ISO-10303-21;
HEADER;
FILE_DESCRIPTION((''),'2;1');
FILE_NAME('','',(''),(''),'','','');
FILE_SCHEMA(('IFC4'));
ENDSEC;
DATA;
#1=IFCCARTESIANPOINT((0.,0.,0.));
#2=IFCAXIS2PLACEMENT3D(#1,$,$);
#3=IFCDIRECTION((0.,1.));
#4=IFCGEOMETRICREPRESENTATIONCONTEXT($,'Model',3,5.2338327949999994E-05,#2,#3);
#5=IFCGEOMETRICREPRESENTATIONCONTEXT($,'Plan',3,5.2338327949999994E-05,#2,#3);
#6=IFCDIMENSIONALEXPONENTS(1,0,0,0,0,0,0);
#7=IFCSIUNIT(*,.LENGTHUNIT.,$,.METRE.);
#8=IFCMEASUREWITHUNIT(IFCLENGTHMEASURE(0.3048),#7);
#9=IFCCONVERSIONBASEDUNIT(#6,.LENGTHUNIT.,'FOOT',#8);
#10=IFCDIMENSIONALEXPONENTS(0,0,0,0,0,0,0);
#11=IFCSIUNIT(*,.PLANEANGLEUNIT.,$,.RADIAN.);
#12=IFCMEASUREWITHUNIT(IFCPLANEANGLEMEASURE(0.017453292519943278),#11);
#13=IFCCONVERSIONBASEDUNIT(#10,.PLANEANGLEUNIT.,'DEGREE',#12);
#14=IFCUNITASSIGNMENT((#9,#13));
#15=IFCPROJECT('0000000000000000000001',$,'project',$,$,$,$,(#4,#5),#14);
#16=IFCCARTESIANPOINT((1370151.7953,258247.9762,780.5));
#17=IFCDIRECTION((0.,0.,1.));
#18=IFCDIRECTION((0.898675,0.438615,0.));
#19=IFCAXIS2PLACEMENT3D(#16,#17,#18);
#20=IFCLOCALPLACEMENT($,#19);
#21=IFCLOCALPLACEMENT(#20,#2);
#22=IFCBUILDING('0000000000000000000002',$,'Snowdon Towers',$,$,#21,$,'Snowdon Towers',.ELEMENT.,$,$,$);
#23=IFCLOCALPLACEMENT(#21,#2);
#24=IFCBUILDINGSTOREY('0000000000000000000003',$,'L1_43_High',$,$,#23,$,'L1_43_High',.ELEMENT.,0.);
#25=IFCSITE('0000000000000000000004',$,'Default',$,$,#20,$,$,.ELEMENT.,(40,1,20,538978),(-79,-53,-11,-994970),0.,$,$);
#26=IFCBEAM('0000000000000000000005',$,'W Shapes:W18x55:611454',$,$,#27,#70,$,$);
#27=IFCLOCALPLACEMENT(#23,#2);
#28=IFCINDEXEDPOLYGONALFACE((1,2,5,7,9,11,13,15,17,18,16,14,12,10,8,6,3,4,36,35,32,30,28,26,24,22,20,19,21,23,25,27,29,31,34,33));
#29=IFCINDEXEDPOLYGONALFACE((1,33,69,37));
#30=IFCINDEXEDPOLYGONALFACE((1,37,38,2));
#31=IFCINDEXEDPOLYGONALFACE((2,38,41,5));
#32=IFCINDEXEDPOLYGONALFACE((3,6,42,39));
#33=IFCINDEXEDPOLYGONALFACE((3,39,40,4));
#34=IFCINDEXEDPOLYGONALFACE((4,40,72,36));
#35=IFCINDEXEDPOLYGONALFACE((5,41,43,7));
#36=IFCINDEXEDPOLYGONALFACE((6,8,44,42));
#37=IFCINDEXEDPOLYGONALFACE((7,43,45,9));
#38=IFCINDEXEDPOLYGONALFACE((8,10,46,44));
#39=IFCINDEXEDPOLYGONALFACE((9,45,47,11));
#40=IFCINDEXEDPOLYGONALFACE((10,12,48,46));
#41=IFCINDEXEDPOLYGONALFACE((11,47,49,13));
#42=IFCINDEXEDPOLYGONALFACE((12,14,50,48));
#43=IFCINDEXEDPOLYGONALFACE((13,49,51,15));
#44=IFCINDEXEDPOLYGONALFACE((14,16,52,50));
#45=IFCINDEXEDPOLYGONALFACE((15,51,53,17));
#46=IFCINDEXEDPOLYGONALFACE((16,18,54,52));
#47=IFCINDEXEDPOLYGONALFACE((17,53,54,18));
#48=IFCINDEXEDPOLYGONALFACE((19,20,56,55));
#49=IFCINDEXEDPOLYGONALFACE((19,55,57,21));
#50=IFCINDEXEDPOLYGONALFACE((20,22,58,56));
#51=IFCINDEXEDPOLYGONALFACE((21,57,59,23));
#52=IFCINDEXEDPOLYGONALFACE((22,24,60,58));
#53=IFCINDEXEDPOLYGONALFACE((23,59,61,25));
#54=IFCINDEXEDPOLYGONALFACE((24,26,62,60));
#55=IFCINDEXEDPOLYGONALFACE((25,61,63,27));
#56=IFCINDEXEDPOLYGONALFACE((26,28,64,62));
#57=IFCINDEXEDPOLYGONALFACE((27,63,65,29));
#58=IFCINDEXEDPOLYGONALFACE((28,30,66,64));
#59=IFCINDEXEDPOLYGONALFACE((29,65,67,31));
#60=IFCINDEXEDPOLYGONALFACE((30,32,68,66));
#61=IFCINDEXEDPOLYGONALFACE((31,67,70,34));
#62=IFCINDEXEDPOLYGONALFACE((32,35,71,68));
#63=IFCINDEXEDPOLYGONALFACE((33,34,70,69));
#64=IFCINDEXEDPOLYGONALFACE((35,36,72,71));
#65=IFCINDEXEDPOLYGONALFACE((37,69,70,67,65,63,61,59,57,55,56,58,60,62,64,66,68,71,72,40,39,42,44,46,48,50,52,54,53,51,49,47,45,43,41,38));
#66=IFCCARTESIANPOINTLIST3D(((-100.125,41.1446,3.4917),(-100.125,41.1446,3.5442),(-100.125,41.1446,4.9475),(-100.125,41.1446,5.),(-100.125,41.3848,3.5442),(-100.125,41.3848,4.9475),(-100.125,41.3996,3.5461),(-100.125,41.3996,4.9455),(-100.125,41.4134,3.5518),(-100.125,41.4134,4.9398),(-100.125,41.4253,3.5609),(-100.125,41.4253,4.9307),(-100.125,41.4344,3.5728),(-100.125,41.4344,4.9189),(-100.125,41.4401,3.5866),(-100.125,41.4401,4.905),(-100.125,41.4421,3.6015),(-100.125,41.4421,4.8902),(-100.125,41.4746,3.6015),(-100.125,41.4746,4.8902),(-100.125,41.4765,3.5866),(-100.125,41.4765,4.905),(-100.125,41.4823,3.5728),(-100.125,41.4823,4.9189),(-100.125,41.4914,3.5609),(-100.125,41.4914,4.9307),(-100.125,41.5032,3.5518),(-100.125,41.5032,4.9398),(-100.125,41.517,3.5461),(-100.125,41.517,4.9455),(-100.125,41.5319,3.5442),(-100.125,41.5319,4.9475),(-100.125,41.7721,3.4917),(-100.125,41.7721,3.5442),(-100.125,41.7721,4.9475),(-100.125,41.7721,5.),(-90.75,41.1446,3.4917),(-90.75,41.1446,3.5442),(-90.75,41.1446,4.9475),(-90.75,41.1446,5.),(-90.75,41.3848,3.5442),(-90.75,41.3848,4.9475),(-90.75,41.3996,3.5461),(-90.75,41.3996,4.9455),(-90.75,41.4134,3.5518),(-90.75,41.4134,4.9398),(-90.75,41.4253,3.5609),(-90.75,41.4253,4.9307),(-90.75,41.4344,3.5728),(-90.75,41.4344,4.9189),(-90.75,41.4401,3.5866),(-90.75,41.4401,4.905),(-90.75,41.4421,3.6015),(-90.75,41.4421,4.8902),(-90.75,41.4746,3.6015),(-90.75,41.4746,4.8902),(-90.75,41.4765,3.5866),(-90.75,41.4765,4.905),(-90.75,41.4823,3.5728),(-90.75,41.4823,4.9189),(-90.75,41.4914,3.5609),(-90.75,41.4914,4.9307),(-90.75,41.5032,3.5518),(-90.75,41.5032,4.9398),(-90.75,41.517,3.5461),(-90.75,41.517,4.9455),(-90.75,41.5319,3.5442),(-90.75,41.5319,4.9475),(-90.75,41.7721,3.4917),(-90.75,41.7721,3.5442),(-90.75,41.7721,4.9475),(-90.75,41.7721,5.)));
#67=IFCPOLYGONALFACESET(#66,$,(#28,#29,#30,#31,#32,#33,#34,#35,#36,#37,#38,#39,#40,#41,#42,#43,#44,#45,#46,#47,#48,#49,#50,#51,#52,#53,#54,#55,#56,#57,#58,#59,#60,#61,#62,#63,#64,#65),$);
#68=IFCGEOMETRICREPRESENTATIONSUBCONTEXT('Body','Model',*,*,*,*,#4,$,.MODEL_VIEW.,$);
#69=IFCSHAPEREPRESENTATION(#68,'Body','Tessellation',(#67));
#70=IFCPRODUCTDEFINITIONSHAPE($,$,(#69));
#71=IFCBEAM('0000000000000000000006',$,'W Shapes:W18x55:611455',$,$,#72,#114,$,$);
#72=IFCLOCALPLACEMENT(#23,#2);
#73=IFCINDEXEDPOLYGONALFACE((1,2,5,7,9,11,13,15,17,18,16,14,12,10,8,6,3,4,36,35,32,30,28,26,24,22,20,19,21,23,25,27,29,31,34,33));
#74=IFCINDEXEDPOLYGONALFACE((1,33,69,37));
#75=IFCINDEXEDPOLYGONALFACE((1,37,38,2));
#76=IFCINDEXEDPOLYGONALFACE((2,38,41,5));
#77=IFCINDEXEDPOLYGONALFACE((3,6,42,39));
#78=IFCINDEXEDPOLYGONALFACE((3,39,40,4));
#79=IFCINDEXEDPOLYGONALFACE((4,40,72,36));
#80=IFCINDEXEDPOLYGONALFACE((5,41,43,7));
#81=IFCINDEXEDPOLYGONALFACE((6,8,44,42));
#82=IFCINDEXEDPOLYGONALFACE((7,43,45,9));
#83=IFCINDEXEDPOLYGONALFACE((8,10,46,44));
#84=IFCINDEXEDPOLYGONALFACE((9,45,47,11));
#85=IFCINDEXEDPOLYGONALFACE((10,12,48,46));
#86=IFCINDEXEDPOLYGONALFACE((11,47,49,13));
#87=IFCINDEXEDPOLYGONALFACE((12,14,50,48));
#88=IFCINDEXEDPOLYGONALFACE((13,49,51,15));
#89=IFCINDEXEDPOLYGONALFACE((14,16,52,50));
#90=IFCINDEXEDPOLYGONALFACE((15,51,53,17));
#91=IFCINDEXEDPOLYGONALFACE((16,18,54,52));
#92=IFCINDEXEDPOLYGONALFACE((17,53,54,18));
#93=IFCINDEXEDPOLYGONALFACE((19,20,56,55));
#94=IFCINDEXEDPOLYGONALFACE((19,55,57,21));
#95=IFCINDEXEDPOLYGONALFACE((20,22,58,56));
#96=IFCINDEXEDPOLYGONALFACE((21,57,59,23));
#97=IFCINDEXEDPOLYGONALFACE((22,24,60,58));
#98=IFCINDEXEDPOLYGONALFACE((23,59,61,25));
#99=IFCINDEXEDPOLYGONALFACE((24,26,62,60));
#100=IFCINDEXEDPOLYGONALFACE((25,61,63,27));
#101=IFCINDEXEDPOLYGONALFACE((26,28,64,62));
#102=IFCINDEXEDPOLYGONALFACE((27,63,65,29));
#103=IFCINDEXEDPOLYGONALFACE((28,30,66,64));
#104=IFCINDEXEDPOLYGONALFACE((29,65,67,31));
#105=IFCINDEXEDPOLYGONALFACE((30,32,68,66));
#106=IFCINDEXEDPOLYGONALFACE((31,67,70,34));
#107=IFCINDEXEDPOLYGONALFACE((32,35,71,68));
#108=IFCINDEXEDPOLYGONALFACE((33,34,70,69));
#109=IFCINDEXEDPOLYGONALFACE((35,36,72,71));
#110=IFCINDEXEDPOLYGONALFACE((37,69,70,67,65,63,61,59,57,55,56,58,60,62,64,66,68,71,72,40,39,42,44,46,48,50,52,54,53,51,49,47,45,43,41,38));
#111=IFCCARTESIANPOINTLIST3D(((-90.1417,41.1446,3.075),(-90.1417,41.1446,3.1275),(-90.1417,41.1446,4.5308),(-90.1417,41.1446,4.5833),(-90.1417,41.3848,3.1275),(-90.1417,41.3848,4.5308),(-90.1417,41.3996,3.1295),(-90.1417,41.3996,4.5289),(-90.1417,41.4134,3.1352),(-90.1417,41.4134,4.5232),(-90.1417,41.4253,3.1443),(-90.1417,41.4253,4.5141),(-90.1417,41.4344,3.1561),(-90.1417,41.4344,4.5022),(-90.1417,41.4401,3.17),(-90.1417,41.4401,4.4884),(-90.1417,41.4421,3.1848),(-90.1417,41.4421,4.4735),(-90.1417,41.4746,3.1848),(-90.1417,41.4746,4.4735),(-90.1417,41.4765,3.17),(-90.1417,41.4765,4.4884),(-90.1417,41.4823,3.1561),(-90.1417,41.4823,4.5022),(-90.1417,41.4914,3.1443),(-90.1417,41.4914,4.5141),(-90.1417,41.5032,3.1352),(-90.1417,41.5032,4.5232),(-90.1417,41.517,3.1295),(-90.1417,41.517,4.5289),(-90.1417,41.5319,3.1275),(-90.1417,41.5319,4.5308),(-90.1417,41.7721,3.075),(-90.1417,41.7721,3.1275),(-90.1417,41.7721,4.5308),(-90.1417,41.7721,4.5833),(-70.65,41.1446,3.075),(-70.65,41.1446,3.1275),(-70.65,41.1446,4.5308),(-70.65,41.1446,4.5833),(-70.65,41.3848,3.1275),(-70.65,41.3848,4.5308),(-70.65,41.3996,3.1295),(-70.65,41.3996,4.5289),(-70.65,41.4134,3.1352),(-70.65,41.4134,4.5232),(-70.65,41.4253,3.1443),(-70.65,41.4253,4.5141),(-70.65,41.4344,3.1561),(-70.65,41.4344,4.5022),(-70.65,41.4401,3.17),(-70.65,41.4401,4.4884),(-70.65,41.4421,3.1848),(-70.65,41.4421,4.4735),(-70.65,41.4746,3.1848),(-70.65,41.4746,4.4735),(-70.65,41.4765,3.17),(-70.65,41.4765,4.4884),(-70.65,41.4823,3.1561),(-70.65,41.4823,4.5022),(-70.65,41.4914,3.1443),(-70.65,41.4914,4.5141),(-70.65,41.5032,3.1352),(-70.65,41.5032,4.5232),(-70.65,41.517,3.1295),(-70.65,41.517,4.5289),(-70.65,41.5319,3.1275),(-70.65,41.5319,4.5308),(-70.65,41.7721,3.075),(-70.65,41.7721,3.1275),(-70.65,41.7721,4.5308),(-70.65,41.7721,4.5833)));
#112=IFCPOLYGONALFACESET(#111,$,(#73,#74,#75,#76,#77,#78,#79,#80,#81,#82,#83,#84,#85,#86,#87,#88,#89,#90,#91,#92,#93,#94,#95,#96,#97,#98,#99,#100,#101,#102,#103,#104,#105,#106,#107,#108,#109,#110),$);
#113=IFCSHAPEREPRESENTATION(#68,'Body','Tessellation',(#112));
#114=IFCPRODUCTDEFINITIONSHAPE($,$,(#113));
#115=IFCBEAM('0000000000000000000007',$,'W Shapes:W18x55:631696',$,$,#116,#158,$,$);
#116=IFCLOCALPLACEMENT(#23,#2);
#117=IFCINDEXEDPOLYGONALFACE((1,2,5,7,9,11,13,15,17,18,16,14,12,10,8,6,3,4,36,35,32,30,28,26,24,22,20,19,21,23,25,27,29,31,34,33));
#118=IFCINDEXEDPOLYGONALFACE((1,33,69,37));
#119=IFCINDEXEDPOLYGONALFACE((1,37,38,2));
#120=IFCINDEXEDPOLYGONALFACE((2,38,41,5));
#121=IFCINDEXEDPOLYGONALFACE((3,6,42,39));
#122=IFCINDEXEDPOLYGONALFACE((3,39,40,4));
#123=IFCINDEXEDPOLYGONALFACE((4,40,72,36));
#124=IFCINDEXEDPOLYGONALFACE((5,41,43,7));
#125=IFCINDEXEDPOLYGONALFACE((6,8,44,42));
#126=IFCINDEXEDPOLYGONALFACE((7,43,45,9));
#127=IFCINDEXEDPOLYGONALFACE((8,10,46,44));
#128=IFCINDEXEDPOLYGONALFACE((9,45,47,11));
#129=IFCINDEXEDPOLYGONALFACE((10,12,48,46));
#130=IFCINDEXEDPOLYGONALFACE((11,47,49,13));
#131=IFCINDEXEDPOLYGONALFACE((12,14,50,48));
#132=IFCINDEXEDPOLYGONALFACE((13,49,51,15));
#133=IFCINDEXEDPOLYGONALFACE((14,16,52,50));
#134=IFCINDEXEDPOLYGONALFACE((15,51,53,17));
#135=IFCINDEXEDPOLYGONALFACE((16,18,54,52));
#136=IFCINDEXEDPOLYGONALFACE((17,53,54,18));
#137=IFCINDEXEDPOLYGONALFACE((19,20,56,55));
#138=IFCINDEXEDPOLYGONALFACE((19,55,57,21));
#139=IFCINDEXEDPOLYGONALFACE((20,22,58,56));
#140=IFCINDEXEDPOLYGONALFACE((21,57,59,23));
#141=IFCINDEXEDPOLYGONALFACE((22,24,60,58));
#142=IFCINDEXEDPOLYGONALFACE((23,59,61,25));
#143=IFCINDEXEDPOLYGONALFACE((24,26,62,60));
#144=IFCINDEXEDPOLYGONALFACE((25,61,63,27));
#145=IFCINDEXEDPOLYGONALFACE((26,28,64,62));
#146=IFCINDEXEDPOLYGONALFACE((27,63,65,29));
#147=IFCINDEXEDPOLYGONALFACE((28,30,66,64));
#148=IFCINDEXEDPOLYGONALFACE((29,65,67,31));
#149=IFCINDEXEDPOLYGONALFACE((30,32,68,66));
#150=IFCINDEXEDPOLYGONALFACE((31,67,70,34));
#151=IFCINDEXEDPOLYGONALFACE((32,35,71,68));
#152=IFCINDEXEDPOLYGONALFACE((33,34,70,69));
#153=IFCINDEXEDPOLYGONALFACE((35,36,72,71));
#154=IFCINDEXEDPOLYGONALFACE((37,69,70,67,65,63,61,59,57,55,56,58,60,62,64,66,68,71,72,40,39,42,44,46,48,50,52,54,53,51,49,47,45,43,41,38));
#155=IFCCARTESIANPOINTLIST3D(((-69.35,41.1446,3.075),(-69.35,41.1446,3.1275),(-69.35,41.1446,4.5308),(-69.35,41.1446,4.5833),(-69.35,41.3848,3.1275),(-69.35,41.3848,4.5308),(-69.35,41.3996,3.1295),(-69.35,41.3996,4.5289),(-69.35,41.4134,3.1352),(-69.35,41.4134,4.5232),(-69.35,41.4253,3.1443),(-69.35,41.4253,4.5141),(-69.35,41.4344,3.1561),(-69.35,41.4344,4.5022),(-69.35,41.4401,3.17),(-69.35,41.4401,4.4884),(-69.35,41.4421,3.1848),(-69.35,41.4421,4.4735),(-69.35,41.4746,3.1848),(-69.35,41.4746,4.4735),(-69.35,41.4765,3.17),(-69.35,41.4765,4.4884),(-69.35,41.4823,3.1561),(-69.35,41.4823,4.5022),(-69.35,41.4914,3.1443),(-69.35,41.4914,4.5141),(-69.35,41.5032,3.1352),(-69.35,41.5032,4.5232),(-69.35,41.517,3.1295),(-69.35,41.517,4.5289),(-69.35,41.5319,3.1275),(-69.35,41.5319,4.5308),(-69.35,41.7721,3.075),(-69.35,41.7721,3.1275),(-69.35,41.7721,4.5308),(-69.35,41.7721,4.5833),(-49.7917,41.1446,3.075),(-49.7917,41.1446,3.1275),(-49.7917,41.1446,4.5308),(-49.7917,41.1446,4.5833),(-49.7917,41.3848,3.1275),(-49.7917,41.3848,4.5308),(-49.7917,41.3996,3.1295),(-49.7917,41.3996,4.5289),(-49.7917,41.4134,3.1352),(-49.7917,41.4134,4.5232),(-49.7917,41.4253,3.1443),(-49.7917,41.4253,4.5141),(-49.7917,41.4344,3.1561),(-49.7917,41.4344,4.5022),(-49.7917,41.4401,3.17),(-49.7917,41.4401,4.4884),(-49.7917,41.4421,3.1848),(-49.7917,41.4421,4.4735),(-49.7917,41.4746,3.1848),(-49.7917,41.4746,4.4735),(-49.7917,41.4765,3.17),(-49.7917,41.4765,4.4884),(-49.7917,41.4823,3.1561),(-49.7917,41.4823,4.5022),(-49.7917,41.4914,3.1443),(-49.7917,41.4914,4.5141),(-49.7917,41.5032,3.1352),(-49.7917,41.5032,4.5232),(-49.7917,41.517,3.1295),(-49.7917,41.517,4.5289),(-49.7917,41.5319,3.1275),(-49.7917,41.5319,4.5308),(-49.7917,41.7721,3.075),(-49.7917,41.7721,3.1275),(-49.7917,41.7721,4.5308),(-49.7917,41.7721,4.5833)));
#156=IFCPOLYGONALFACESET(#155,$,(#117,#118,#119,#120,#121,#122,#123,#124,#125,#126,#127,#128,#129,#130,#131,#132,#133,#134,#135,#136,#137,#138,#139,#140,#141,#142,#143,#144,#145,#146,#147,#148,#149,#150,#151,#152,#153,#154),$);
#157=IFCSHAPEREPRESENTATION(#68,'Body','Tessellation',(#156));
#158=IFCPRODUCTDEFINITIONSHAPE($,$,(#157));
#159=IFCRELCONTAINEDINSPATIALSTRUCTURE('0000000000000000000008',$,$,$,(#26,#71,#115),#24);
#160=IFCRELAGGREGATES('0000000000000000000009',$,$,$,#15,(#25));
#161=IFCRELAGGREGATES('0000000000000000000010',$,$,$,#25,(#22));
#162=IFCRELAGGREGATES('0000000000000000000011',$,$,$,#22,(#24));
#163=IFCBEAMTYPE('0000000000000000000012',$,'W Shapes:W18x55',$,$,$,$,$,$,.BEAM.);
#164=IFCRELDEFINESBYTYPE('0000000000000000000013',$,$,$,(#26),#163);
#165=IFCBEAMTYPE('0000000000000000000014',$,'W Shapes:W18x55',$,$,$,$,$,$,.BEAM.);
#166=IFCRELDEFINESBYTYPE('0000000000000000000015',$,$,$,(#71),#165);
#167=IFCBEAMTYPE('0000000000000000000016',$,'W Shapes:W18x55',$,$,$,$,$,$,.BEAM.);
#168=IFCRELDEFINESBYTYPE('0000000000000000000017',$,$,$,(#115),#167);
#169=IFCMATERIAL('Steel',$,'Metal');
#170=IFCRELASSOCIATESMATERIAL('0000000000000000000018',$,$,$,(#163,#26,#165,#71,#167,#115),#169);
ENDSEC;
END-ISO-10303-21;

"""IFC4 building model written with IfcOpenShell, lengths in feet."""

from ifc_helpers import new_model, entity, si_unit, converted_unit, direction, frame, origin, place, context, subcontext, project, spatial, line, arc, indexed_curve, outline, extrude, source, transform, mapped, material, type_object, type_shapes, element, save


model = new_model("IFC4")

# Units and contexts
model_context = context("Model", 3, precision=5.2338327949999994e-05, world=origin(), true_north=direction((0.0, 1.0)))
plan_context = context("Plan", 3, precision=5.2338327949999994e-05, world=origin(), true_north=direction((0.0, 1.0)))
body_context = subcontext(model_context, "Body", "Model", "MODEL_VIEW")
ifc_project = project(units=[converted_unit("LENGTHUNIT", "FOOT", entity("IfcLengthMeasure", 0.3048), si_unit("LENGTHUNIT", "METRE"), dimensions=[1, 0, 0, 0, 0, 0, 0]), converted_unit("PLANEANGLEUNIT", "DEGREE", entity("IfcPlaneAngleMeasure", 0.017453292519943278), si_unit("PLANEANGLEUNIT", "RADIAN"), dimensions=[0, 0, 0, 0, 0, 0, 0])], contexts=[model_context, plan_context])

# Site, building, storey
site_placement = place(None, frame((1370151.7953, 258247.9762, 780.5), z_axis=(0.0, 0.0, 1.0), x_axis=(0.898675, 0.438615, 0.0)))
site = spatial("IfcSite", under=ifc_project, at=site_placement, Name="Default", CompositionType="ELEMENT", RefLatitude=(40, 1, 20, 538978), RefLongitude=(-79, -53, -11, -994970), RefElevation=0.0)
building_placement = place(site_placement, origin())
building = spatial("IfcBuilding", under=site, at=building_placement, Name="Snowdon Towers", LongName="Snowdon Towers", CompositionType="ELEMENT")
storey_placement = place(building_placement, origin())
storey = spatial("IfcBuildingStorey", under=building, at=storey_placement, Name="L1_43_High", LongName="L1_43_High", CompositionType="ELEMENT", Elevation=0.0)

# Shared definitions
ifc_material_1 = material(Name="Steel", Category="Metal")

# Beams
beam_type_1 = type_object("IfcBeamType", Name="W Shapes:W18x55", PredefinedType="BEAM", material=ifc_material_1)
shared_shape_1 = source(origin(), body_context, "Body", "SweptSolid", [
    extrude(outline(indexed_curve([(-0.7542, -0.3138), (-0.7017, -0.3138), (-0.7017, -0.0735), (-0.6849, -0.033), (-0.6444, -0.0162), (0.6444, -0.0162), (0.6849, -0.033), (0.7017, -0.0735), (0.7017, -0.3138), (0.7542, -0.3138), (0.7542, 0.3138), (0.7017, 0.3138), (0.7017, 0.0735), (0.6849, 0.033), (0.6444, 0.0163), (-0.6444, 0.0163), (-0.6849, 0.033), (-0.7017, 0.0735), (-0.7017, 0.3137), (-0.7542, 0.3137)], segments=[line(1, 2, 3), arc(3, 4, 5), line(5, 6), arc(6, 7, 8), line(8, 9, 10, 11, 12, 13), arc(13, 14, 15), line(15, 16), arc(16, 17, 18), line(18, 19, 20, 1)], self_intersect=False)), frame((-4.6875, 0.0, 0.0), z_axis=(1.0, 0.0, 0.0), x_axis=(0.0, 0.0, -1.0)), (0.0, 0.0, 1.0), 9.375),
])
type_shapes(beam_type_1, [shared_shape_1])
beam_1_placement = place(storey_placement, frame((-95.4375, 41.4583, 4.2458)))
element("IfcBeam", 1, at=beam_1_placement, inside=storey, type_object=beam_type_1, material=ifc_material_1, Name="W Shapes:W18x55:611454", context=body_context, shape_type="MappedRepresentation", body=[
    mapped(shared_shape_1, transform((0.0, 0.0, 0.0), scale=1.0)),
])
beam_type_2 = type_object("IfcBeamType", Name="W Shapes:W18x55", PredefinedType="BEAM", material=ifc_material_1)
shared_shape_2 = source(origin(), body_context, "Body", "SweptSolid", [
    extrude(outline(indexed_curve([(-0.7542, -0.3138), (-0.7017, -0.3138), (-0.7017, -0.0735), (-0.6849, -0.033), (-0.6444, -0.0162), (0.6444, -0.0162), (0.6849, -0.033), (0.7017, -0.0735), (0.7017, -0.3138), (0.7542, -0.3138), (0.7542, 0.3138), (0.7017, 0.3138), (0.7017, 0.0735), (0.6849, 0.033), (0.6444, 0.0163), (-0.6444, 0.0163), (-0.6849, 0.033), (-0.7017, 0.0735), (-0.7017, 0.3137), (-0.7542, 0.3137)], segments=[line(1, 2, 3), arc(3, 4, 5), line(5, 6), arc(6, 7, 8), line(8, 9, 10, 11, 12, 13), arc(13, 14, 15), line(15, 16), arc(16, 17, 18), line(18, 19, 20, 1)], self_intersect=False)), frame((-9.7875, 0.0, 0.0), z_axis=(1.0, 0.0, 0.0), x_axis=(0.0, 0.0, -1.0)), (0.0, 0.0, 1.0), 19.4917),
])
type_shapes(beam_type_2, [shared_shape_2])
beam_2_placement = place(storey_placement, frame((-80.3542, 41.4583, 3.8292)))
element("IfcBeam", 2, at=beam_2_placement, inside=storey, type_object=beam_type_2, material=ifc_material_1, Name="W Shapes:W18x55:611455", context=body_context, shape_type="MappedRepresentation", body=[
    mapped(shared_shape_2, transform((0.0, 0.0, 0.0), scale=1.0)),
])
beam_type_3 = type_object("IfcBeamType", Name="W Shapes:W18x55", PredefinedType="BEAM", material=ifc_material_1)
shared_shape_3 = source(origin(), body_context, "Body", "SweptSolid", [
    extrude(outline(indexed_curve([(-0.7542, -0.3138), (-0.7017, -0.3138), (-0.7017, -0.0735), (-0.6849, -0.033), (-0.6444, -0.0162), (0.6444, -0.0162), (0.6849, -0.033), (0.7017, -0.0735), (0.7017, -0.3138), (0.7542, -0.3138), (0.7542, 0.3138), (0.7017, 0.3138), (0.7017, 0.0735), (0.6849, 0.033), (0.6444, 0.0163), (-0.6444, 0.0163), (-0.6849, 0.033), (-0.7017, 0.0735), (-0.7017, 0.3137), (-0.7542, 0.3137)], segments=[line(1, 2, 3), arc(3, 4, 5), line(5, 6), arc(6, 7, 8), line(8, 9, 10, 11, 12, 13), arc(13, 14, 15), line(15, 16), arc(16, 17, 18), line(18, 19, 20, 1)], self_intersect=False)), frame((-9.725, 0.0, 0.0), z_axis=(1.0, 0.0, 0.0), x_axis=(0.0, 0.0, -1.0)), (0.0, 0.0, 1.0), 19.5583),
])
type_shapes(beam_type_3, [shared_shape_3])
beam_3_placement = place(storey_placement, frame((-59.625, 41.4583, 3.8292)))
element("IfcBeam", 3, at=beam_3_placement, inside=storey, type_object=beam_type_3, material=ifc_material_1, Name="W Shapes:W18x55:631696", context=body_context, shape_type="MappedRepresentation", body=[
    mapped(shared_shape_3, transform((0.0, 0.0, 0.0), scale=1.0)),
])

save(model, "model.ifc")
